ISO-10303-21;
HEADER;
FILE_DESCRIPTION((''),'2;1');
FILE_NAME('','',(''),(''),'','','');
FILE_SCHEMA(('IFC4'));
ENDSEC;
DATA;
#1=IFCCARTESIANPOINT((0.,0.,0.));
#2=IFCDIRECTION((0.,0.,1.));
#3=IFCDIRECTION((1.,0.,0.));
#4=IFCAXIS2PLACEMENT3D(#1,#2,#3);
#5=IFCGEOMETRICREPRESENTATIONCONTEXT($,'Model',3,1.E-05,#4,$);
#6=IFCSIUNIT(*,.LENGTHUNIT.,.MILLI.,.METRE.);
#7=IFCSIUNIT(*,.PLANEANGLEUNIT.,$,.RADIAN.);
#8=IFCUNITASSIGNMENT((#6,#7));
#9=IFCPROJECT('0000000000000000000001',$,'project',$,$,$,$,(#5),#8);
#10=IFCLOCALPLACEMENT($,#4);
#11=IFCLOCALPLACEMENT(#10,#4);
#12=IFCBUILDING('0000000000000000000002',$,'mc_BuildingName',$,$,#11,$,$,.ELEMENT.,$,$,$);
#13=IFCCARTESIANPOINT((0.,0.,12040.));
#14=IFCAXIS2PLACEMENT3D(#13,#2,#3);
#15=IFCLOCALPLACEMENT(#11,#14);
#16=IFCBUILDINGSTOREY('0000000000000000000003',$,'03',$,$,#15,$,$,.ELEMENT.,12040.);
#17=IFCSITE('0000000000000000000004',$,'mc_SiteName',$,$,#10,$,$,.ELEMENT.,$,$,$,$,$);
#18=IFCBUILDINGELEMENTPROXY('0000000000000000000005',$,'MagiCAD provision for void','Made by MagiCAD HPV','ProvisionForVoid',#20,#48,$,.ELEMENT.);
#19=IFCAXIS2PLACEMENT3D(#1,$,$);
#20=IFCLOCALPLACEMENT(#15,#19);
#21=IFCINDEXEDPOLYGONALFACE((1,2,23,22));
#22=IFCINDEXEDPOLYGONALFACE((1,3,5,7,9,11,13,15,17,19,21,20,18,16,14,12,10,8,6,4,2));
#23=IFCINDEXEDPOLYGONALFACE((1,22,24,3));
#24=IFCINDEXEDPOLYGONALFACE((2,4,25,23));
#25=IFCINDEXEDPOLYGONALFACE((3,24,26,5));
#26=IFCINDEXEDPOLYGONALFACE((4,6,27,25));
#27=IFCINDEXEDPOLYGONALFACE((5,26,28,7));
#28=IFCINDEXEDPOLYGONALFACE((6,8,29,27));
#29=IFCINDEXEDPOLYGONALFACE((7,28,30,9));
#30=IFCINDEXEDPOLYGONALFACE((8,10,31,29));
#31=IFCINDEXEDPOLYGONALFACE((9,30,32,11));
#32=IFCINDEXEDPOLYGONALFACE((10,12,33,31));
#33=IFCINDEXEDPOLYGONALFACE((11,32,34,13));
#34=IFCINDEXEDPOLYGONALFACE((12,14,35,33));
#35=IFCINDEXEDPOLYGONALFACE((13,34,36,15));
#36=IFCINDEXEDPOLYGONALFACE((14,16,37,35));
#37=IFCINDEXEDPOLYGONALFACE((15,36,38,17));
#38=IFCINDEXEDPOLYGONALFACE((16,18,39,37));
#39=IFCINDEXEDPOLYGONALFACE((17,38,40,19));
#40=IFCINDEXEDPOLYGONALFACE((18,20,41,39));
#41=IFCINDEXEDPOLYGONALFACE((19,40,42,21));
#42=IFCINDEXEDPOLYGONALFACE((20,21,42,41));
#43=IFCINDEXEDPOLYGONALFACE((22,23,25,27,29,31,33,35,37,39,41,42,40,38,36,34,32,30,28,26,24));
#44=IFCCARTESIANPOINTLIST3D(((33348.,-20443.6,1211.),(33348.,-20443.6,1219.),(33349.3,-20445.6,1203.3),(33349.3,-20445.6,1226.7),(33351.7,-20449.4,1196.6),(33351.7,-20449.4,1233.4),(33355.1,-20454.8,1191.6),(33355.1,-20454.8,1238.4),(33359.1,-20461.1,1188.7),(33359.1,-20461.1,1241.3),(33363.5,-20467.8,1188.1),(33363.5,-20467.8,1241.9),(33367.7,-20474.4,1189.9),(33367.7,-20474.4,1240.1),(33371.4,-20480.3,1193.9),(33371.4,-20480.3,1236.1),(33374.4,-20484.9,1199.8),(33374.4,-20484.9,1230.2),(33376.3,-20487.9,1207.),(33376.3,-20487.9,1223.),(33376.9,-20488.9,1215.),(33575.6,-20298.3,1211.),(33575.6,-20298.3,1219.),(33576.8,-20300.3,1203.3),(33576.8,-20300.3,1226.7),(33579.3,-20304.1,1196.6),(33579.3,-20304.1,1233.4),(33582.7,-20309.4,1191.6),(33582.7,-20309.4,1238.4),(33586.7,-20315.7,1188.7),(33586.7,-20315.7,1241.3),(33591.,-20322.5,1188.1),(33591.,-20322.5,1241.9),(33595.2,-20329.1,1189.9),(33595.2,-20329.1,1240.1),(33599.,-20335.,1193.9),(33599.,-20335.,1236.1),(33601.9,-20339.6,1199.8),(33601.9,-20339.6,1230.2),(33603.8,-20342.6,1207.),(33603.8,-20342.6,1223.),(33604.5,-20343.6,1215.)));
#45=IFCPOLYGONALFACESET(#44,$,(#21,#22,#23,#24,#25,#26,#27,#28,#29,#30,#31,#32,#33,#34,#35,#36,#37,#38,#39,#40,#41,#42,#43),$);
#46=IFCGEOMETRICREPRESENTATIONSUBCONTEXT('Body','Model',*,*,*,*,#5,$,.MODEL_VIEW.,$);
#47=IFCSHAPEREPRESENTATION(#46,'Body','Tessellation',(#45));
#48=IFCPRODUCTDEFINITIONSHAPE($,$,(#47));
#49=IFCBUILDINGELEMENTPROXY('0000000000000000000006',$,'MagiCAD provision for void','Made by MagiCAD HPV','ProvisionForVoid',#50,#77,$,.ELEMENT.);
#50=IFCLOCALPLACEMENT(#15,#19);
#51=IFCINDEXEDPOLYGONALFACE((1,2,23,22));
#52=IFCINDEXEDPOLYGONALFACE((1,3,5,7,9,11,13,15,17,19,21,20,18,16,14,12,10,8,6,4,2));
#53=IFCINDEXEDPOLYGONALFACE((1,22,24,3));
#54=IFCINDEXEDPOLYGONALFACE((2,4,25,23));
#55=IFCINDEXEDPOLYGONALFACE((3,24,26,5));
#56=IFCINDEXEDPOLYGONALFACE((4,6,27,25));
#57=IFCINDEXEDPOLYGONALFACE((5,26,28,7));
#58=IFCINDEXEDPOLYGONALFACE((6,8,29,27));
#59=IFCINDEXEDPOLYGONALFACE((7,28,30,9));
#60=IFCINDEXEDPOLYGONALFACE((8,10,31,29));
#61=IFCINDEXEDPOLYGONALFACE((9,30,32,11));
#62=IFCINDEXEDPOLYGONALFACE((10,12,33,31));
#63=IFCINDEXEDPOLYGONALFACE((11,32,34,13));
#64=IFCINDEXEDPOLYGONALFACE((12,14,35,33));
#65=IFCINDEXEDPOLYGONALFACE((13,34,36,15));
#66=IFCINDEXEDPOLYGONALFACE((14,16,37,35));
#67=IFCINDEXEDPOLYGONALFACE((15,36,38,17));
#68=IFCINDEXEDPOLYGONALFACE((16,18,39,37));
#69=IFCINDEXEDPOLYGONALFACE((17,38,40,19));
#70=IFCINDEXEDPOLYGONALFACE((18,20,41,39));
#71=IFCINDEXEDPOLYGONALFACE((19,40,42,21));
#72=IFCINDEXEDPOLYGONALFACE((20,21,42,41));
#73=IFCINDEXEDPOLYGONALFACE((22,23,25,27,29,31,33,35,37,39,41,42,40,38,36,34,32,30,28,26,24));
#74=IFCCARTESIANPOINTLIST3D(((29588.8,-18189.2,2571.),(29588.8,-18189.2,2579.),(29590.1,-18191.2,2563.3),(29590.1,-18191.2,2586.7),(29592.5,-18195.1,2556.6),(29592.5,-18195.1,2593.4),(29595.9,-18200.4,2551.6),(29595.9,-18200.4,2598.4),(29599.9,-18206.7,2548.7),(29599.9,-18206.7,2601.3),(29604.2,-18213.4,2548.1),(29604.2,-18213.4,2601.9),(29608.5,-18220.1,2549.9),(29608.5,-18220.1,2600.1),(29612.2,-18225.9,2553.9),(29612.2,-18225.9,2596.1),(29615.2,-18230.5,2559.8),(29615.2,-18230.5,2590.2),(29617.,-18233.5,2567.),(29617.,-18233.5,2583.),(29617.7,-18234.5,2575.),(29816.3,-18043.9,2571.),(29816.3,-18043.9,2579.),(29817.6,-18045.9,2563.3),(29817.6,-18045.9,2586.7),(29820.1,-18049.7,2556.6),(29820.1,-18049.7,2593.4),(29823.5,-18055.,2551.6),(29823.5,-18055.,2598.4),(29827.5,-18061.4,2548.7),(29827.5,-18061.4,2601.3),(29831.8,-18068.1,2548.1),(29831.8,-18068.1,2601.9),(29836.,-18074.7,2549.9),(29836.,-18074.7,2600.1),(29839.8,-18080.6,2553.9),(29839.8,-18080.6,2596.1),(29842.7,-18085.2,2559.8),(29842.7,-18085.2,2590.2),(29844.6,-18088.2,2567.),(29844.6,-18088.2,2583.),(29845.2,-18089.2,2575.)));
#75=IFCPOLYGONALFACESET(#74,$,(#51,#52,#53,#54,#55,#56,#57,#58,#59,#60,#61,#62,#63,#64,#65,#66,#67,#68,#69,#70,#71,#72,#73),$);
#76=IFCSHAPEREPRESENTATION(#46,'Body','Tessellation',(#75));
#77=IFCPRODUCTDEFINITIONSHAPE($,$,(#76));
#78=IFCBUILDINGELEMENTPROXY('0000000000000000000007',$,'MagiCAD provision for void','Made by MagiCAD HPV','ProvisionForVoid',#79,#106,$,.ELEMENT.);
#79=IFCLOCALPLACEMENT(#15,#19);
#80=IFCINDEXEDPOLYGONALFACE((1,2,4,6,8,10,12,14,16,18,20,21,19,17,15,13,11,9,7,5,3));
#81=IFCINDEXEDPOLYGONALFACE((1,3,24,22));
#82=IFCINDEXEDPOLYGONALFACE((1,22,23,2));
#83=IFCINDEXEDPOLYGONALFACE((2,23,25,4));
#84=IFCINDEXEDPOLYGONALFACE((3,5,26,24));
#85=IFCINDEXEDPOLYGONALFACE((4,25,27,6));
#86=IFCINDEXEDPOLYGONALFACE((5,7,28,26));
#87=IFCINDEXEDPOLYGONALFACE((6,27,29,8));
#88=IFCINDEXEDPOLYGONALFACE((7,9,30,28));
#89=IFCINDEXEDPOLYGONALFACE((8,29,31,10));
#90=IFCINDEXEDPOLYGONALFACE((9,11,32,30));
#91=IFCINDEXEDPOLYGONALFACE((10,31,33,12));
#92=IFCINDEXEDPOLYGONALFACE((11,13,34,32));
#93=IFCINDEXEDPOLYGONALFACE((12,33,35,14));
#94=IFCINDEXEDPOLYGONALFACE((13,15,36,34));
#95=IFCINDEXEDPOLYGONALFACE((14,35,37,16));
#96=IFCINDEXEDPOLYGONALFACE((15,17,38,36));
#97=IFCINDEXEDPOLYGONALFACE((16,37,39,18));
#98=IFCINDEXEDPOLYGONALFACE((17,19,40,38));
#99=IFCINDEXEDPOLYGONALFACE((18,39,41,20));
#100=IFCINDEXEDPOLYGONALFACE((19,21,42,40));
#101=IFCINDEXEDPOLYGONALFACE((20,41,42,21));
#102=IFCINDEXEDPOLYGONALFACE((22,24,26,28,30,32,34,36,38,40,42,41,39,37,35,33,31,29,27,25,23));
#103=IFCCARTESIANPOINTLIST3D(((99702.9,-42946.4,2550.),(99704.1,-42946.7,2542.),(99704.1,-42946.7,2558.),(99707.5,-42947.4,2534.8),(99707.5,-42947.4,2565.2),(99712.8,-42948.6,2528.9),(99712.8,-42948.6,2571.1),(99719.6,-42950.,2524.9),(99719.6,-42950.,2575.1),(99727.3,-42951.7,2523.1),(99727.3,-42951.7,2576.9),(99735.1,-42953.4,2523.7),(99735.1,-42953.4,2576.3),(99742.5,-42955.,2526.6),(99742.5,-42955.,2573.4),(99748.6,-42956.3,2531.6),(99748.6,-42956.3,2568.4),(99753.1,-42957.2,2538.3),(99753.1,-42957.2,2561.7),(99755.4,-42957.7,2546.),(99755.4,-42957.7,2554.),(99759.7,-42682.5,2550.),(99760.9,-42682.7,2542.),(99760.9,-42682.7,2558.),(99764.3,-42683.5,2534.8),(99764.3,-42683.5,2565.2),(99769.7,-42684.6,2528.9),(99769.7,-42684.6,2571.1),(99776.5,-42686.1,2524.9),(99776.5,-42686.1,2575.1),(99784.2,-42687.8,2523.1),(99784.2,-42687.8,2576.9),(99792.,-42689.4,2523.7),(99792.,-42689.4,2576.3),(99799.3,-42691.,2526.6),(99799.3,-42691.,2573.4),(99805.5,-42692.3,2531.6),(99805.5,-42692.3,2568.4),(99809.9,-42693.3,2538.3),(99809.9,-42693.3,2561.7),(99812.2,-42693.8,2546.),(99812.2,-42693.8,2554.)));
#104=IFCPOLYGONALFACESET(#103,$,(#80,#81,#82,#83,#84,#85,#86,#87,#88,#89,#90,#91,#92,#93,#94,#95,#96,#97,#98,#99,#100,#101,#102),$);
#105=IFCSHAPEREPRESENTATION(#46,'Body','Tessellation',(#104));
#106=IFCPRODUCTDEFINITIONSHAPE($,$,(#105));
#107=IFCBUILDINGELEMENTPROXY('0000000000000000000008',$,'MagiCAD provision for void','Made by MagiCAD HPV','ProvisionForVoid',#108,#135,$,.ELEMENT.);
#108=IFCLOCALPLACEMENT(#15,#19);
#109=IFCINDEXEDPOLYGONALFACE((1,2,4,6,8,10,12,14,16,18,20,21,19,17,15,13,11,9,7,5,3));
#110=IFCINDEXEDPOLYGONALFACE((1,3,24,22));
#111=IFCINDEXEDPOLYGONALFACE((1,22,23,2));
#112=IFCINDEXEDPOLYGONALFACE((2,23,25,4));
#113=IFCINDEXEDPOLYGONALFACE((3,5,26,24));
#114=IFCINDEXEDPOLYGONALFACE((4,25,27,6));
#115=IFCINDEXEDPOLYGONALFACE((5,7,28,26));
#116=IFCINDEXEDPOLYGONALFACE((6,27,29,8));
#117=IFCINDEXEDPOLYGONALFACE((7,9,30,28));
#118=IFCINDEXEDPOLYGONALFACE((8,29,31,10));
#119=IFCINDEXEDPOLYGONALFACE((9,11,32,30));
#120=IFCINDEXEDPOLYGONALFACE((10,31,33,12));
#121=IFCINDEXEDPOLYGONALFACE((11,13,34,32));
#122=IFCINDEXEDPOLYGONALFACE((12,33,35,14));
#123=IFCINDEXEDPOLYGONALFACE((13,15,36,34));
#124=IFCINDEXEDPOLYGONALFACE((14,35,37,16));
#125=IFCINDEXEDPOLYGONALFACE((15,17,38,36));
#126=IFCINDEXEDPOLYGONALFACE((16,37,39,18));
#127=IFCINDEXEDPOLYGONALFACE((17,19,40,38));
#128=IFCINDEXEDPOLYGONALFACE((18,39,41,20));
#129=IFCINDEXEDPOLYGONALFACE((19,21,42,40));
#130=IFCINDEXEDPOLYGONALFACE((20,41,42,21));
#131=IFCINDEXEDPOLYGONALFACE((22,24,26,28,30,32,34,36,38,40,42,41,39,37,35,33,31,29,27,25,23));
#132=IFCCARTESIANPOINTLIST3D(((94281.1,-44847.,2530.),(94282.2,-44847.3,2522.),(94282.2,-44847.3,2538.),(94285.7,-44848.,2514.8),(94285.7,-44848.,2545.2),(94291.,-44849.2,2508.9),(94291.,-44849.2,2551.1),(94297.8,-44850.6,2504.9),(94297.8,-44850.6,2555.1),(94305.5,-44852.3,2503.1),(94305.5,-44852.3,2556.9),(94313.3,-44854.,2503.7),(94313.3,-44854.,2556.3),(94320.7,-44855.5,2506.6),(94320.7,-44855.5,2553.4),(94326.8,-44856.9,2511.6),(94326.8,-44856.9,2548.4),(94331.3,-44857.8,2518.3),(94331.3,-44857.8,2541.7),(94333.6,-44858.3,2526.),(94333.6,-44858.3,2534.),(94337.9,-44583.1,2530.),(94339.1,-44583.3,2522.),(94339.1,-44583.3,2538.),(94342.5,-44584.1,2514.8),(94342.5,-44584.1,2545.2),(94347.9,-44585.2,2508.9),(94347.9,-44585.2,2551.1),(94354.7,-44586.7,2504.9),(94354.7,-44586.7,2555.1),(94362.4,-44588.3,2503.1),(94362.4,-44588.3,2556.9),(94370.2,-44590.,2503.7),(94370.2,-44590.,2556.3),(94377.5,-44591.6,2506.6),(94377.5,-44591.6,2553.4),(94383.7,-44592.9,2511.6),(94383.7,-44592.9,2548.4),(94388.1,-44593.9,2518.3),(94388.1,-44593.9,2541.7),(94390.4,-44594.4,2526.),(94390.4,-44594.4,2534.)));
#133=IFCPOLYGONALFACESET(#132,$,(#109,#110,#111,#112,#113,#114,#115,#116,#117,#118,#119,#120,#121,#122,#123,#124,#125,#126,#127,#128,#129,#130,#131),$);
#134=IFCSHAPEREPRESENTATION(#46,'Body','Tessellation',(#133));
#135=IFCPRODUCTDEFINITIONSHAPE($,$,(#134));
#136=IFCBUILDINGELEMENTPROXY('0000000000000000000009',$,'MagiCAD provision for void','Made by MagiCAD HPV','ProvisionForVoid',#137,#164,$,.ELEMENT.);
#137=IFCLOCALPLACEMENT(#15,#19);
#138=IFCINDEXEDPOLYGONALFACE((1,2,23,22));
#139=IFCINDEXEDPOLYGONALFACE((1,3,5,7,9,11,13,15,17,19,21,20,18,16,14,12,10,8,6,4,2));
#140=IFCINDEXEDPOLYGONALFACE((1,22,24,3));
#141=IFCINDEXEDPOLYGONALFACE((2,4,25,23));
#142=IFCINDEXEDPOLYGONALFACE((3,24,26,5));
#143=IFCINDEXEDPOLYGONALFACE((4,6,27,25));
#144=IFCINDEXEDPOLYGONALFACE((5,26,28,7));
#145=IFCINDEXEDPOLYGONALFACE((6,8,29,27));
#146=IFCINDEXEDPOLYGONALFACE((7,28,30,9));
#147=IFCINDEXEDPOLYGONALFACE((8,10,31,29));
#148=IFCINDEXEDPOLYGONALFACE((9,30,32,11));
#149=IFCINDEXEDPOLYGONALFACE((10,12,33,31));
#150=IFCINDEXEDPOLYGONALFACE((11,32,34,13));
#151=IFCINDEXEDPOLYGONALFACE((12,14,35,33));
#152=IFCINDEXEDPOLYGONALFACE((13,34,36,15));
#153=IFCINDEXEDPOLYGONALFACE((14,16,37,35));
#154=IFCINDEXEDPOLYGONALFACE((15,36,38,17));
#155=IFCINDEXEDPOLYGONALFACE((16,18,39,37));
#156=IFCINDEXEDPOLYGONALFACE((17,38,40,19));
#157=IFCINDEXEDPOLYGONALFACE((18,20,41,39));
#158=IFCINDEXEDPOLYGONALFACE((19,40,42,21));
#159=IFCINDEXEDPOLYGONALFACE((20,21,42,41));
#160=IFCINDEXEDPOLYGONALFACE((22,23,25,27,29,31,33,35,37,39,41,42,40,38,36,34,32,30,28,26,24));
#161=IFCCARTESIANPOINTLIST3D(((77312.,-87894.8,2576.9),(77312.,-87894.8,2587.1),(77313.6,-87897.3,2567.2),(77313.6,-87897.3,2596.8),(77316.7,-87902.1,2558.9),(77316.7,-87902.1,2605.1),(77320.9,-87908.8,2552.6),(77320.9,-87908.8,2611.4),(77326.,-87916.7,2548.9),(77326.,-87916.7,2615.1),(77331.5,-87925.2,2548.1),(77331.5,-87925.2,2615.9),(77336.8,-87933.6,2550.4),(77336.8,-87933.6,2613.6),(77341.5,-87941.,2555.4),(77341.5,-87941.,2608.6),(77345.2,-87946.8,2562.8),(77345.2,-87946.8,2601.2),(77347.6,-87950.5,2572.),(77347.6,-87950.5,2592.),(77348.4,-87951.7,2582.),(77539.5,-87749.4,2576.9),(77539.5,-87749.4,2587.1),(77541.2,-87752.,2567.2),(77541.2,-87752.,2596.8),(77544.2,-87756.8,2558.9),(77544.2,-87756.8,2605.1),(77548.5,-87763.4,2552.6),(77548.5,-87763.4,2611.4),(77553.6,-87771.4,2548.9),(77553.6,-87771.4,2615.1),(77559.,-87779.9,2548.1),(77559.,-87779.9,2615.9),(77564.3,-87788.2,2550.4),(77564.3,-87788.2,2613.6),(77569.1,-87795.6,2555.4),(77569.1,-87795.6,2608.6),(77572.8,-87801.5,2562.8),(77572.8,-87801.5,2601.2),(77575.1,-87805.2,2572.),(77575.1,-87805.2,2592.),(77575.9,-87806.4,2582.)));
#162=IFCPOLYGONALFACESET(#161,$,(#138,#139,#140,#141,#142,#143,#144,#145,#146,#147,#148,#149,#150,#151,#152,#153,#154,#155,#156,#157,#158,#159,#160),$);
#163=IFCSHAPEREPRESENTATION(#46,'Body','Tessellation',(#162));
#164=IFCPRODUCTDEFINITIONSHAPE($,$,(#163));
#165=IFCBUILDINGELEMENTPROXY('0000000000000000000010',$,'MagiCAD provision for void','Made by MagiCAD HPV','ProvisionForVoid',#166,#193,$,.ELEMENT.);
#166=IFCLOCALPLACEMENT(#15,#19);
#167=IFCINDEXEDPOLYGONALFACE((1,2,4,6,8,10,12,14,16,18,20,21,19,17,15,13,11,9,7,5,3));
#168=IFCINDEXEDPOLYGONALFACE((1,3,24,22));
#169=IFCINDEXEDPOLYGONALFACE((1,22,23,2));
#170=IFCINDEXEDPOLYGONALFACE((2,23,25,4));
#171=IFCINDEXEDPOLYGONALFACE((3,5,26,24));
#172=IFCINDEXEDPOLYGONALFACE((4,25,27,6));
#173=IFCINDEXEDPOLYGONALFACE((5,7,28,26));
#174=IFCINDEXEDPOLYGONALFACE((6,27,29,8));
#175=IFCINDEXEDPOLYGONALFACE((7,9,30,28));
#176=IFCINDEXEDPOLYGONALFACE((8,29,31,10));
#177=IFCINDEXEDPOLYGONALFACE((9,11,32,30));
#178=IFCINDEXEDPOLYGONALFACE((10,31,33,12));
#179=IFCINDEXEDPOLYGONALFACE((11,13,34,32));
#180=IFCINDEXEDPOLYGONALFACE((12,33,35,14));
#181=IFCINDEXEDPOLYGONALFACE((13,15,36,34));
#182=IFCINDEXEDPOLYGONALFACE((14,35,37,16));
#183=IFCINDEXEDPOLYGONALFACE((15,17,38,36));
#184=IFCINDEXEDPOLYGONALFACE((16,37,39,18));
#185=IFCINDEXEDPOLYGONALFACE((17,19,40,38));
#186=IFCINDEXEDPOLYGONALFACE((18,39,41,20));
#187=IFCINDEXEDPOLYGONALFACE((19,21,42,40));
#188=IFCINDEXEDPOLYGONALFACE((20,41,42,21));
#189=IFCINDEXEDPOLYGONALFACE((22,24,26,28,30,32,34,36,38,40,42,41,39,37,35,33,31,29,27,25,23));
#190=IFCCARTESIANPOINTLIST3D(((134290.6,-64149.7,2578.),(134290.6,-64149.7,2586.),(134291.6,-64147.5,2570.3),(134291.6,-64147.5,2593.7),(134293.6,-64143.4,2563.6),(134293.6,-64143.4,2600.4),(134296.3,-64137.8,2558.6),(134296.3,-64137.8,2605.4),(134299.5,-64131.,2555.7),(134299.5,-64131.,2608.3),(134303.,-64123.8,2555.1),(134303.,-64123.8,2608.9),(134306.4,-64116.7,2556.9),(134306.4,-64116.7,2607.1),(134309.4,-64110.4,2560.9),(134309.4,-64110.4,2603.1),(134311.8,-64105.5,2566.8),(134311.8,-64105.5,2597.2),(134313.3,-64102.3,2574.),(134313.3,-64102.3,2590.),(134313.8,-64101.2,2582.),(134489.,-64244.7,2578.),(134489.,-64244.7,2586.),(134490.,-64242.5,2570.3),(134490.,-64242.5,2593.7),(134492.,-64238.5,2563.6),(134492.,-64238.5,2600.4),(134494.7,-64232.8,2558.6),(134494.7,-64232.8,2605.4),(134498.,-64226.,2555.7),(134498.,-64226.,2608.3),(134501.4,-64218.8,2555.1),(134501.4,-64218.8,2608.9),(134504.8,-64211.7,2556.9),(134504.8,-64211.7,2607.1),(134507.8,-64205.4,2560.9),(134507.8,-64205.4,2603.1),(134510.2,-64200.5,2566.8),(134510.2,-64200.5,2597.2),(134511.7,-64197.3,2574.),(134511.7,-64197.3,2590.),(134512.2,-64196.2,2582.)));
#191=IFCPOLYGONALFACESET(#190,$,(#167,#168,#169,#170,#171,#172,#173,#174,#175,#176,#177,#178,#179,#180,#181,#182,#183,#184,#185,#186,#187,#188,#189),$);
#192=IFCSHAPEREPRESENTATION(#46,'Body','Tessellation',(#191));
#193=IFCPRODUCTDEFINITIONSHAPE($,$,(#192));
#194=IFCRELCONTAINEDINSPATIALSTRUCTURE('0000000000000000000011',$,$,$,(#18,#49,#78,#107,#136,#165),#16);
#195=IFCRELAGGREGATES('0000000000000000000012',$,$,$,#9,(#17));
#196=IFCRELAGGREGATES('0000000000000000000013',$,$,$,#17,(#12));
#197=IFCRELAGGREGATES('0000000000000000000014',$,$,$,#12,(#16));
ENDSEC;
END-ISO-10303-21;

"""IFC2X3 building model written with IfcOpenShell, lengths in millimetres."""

from ifc_helpers import new_model, si_unit, frame, origin_with_axes, origin_2d_with_axis, place, context, subcontext, project, spatial, circle, extrude, source, transform, mapped, element, save


model = new_model("IFC2X3")

# Units and contexts
model_context = context("Model", 3, precision=1e-05, world=origin_with_axes())
body_context = subcontext(model_context, "Body", "Model", "MODEL_VIEW")
ifc_project = project(units=[si_unit("LENGTHUNIT", "METRE", prefix="MILLI"), si_unit("PLANEANGLEUNIT", "RADIAN")], contexts=[model_context])

# Site, building, storey
site_placement = place(None, origin_with_axes())
site = spatial("IfcSite", under=ifc_project, at=site_placement, Name="mc_SiteName", CompositionType="ELEMENT")
building_placement = place(site_placement, origin_with_axes())
building = spatial("IfcBuilding", under=site, at=building_placement, Name="mc_BuildingName", CompositionType="ELEMENT")
storey_placement = place(building_placement, frame((0.0, 0.0, 12040.0), z_axis=(0.0, 0.0, 1.0), x_axis=(1.0, 0.0, 0.0)))
storey = spatial("IfcBuildingStorey", under=building, at=storey_placement, Name="03", CompositionType="ELEMENT", Elevation=12040.0)

# Building element proxies
shared_shape_1 = source(origin_with_axes(), body_context, "Body", "SweptSolid", [
    extrude(circle(Radius=27.0, at=origin_2d_with_axis()), frame((0.0, 0.0, 0.0), z_axis=(1.0, 0.0, 0.0), x_axis=(0.0, 1.0, 0.0)), (0.0, 0.0, 1.0), 270.0),
])
proxy_1_placement = place(storey_placement, frame((33589.9, -20320.8, 1215.0), z_axis=(0.0, 0.0, 1.0), x_axis=(-0.842809, -0.538213, 0.0)))
element("IfcBuildingElementProxy", 1, at=proxy_1_placement, inside=storey, Name="MagiCAD provision for void", Description="Made by MagiCAD HPV", ObjectType="ProvisionForVoid", CompositionType="ELEMENT", context=body_context, shape_type="MappedRepresentation", body=[
    mapped(shared_shape_1, transform((0.0, 0.0, 0.0), scale=1.0)),
])
shared_shape_2 = source(origin_with_axes(), body_context, "Body", "SweptSolid", [
    extrude(circle(Radius=27.0, at=origin_2d_with_axis()), frame((0.0, 0.0, 0.0), z_axis=(1.0, 0.0, 0.0), x_axis=(0.0, 1.0, 0.0)), (0.0, 0.0, 1.0), 270.0),
])
proxy_2_placement = place(storey_placement, frame((29830.7, -18066.4, 2575.0), z_axis=(0.0, 0.0, 1.0), x_axis=(-0.842809, -0.538213, 0.0)))
element("IfcBuildingElementProxy", 2, at=proxy_2_placement, inside=storey, Name="MagiCAD provision for void", Description="Made by MagiCAD HPV", ObjectType="ProvisionForVoid", CompositionType="ELEMENT", context=body_context, shape_type="MappedRepresentation", body=[
    mapped(shared_shape_2, transform((0.0, 0.0, 0.0), scale=1.0)),
])
shared_shape_3 = source(origin_with_axes(), body_context, "Body", "SweptSolid", [
    extrude(circle(Radius=27.0, at=origin_2d_with_axis()), frame((0.0, 0.0, 0.0), z_axis=(1.0, 0.0, 0.0), x_axis=(0.0, 1.0, 0.0)), (0.0, 0.0, 1.0), 270.0),
])
proxy_3_placement = place(storey_placement, frame((99729.3, -42952.1, 2550.0), z_axis=(0.0, 0.0, 1.0), x_axis=(0.210582, 0.977576, 0.0)))
element("IfcBuildingElementProxy", 3, at=proxy_3_placement, inside=storey, Name="MagiCAD provision for void", Description="Made by MagiCAD HPV", ObjectType="ProvisionForVoid", CompositionType="ELEMENT", context=body_context, shape_type="MappedRepresentation", body=[
    mapped(shared_shape_3, transform((0.0, 0.0, 0.0), scale=1.0)),
])
shared_shape_4 = source(origin_with_axes(), body_context, "Body", "SweptSolid", [
    extrude(circle(Radius=27.0, at=origin_2d_with_axis()), frame((0.0, 0.0, 0.0), z_axis=(1.0, 0.0, 0.0), x_axis=(0.0, 1.0, 0.0)), (0.0, 0.0, 1.0), 270.0),
])
proxy_4_placement = place(storey_placement, frame((94307.5, -44852.7, 2530.0), z_axis=(0.0, 0.0, 1.0), x_axis=(0.210642, 0.977563, 0.0)))
element("IfcBuildingElementProxy", 4, at=proxy_4_placement, inside=storey, Name="MagiCAD provision for void", Description="Made by MagiCAD HPV", ObjectType="ProvisionForVoid", CompositionType="ELEMENT", context=body_context, shape_type="MappedRepresentation", body=[
    mapped(shared_shape_4, transform((0.0, 0.0, 0.0), scale=1.0)),
])
shared_shape_5 = source(origin_with_axes(), body_context, "Body", "SweptSolid", [
    extrude(circle(Radius=34.0, at=origin_2d_with_axis()), frame((0.0, 0.0, 0.0), z_axis=(1.0, 0.0, 0.0), x_axis=(0.0, 1.0, 0.0)), (0.0, 0.0, 1.0), 270.0),
])
proxy_5_placement = place(storey_placement, frame((77557.6, -87777.8, 2582.0), z_axis=(0.0, 0.0, 1.0), x_axis=(-0.842809, -0.538213, 0.0)))
element("IfcBuildingElementProxy", 5, at=proxy_5_placement, inside=storey, Name="MagiCAD provision for void", Description="Made by MagiCAD HPV", ObjectType="ProvisionForVoid", CompositionType="ELEMENT", context=body_context, shape_type="MappedRepresentation", body=[
    mapped(shared_shape_5, transform((0.0, 0.0, 0.0), scale=1.0)),
])
shared_shape_6 = source(origin_with_axes(), body_context, "Body", "SweptSolid", [
    extrude(circle(Radius=27.0, at=origin_2d_with_axis()), frame((0.0, 0.0, 0.0), z_axis=(1.0, 0.0, 0.0), x_axis=(0.0, 1.0, 0.0)), (0.0, 0.0, 1.0), 220.0),
])
proxy_6_placement = place(storey_placement, frame((134302.1, -64125.6, 2582.0), z_axis=(0.0, 0.0, 1.0), x_axis=(0.901941, -0.431859, 0.0)))
element("IfcBuildingElementProxy", 6, at=proxy_6_placement, inside=storey, Name="MagiCAD provision for void", Description="Made by MagiCAD HPV", ObjectType="ProvisionForVoid", CompositionType="ELEMENT", context=body_context, shape_type="MappedRepresentation", body=[
    mapped(shared_shape_6, transform((0.0, 0.0, 0.0), scale=1.0)),
])

save(model, "model.ifc")
